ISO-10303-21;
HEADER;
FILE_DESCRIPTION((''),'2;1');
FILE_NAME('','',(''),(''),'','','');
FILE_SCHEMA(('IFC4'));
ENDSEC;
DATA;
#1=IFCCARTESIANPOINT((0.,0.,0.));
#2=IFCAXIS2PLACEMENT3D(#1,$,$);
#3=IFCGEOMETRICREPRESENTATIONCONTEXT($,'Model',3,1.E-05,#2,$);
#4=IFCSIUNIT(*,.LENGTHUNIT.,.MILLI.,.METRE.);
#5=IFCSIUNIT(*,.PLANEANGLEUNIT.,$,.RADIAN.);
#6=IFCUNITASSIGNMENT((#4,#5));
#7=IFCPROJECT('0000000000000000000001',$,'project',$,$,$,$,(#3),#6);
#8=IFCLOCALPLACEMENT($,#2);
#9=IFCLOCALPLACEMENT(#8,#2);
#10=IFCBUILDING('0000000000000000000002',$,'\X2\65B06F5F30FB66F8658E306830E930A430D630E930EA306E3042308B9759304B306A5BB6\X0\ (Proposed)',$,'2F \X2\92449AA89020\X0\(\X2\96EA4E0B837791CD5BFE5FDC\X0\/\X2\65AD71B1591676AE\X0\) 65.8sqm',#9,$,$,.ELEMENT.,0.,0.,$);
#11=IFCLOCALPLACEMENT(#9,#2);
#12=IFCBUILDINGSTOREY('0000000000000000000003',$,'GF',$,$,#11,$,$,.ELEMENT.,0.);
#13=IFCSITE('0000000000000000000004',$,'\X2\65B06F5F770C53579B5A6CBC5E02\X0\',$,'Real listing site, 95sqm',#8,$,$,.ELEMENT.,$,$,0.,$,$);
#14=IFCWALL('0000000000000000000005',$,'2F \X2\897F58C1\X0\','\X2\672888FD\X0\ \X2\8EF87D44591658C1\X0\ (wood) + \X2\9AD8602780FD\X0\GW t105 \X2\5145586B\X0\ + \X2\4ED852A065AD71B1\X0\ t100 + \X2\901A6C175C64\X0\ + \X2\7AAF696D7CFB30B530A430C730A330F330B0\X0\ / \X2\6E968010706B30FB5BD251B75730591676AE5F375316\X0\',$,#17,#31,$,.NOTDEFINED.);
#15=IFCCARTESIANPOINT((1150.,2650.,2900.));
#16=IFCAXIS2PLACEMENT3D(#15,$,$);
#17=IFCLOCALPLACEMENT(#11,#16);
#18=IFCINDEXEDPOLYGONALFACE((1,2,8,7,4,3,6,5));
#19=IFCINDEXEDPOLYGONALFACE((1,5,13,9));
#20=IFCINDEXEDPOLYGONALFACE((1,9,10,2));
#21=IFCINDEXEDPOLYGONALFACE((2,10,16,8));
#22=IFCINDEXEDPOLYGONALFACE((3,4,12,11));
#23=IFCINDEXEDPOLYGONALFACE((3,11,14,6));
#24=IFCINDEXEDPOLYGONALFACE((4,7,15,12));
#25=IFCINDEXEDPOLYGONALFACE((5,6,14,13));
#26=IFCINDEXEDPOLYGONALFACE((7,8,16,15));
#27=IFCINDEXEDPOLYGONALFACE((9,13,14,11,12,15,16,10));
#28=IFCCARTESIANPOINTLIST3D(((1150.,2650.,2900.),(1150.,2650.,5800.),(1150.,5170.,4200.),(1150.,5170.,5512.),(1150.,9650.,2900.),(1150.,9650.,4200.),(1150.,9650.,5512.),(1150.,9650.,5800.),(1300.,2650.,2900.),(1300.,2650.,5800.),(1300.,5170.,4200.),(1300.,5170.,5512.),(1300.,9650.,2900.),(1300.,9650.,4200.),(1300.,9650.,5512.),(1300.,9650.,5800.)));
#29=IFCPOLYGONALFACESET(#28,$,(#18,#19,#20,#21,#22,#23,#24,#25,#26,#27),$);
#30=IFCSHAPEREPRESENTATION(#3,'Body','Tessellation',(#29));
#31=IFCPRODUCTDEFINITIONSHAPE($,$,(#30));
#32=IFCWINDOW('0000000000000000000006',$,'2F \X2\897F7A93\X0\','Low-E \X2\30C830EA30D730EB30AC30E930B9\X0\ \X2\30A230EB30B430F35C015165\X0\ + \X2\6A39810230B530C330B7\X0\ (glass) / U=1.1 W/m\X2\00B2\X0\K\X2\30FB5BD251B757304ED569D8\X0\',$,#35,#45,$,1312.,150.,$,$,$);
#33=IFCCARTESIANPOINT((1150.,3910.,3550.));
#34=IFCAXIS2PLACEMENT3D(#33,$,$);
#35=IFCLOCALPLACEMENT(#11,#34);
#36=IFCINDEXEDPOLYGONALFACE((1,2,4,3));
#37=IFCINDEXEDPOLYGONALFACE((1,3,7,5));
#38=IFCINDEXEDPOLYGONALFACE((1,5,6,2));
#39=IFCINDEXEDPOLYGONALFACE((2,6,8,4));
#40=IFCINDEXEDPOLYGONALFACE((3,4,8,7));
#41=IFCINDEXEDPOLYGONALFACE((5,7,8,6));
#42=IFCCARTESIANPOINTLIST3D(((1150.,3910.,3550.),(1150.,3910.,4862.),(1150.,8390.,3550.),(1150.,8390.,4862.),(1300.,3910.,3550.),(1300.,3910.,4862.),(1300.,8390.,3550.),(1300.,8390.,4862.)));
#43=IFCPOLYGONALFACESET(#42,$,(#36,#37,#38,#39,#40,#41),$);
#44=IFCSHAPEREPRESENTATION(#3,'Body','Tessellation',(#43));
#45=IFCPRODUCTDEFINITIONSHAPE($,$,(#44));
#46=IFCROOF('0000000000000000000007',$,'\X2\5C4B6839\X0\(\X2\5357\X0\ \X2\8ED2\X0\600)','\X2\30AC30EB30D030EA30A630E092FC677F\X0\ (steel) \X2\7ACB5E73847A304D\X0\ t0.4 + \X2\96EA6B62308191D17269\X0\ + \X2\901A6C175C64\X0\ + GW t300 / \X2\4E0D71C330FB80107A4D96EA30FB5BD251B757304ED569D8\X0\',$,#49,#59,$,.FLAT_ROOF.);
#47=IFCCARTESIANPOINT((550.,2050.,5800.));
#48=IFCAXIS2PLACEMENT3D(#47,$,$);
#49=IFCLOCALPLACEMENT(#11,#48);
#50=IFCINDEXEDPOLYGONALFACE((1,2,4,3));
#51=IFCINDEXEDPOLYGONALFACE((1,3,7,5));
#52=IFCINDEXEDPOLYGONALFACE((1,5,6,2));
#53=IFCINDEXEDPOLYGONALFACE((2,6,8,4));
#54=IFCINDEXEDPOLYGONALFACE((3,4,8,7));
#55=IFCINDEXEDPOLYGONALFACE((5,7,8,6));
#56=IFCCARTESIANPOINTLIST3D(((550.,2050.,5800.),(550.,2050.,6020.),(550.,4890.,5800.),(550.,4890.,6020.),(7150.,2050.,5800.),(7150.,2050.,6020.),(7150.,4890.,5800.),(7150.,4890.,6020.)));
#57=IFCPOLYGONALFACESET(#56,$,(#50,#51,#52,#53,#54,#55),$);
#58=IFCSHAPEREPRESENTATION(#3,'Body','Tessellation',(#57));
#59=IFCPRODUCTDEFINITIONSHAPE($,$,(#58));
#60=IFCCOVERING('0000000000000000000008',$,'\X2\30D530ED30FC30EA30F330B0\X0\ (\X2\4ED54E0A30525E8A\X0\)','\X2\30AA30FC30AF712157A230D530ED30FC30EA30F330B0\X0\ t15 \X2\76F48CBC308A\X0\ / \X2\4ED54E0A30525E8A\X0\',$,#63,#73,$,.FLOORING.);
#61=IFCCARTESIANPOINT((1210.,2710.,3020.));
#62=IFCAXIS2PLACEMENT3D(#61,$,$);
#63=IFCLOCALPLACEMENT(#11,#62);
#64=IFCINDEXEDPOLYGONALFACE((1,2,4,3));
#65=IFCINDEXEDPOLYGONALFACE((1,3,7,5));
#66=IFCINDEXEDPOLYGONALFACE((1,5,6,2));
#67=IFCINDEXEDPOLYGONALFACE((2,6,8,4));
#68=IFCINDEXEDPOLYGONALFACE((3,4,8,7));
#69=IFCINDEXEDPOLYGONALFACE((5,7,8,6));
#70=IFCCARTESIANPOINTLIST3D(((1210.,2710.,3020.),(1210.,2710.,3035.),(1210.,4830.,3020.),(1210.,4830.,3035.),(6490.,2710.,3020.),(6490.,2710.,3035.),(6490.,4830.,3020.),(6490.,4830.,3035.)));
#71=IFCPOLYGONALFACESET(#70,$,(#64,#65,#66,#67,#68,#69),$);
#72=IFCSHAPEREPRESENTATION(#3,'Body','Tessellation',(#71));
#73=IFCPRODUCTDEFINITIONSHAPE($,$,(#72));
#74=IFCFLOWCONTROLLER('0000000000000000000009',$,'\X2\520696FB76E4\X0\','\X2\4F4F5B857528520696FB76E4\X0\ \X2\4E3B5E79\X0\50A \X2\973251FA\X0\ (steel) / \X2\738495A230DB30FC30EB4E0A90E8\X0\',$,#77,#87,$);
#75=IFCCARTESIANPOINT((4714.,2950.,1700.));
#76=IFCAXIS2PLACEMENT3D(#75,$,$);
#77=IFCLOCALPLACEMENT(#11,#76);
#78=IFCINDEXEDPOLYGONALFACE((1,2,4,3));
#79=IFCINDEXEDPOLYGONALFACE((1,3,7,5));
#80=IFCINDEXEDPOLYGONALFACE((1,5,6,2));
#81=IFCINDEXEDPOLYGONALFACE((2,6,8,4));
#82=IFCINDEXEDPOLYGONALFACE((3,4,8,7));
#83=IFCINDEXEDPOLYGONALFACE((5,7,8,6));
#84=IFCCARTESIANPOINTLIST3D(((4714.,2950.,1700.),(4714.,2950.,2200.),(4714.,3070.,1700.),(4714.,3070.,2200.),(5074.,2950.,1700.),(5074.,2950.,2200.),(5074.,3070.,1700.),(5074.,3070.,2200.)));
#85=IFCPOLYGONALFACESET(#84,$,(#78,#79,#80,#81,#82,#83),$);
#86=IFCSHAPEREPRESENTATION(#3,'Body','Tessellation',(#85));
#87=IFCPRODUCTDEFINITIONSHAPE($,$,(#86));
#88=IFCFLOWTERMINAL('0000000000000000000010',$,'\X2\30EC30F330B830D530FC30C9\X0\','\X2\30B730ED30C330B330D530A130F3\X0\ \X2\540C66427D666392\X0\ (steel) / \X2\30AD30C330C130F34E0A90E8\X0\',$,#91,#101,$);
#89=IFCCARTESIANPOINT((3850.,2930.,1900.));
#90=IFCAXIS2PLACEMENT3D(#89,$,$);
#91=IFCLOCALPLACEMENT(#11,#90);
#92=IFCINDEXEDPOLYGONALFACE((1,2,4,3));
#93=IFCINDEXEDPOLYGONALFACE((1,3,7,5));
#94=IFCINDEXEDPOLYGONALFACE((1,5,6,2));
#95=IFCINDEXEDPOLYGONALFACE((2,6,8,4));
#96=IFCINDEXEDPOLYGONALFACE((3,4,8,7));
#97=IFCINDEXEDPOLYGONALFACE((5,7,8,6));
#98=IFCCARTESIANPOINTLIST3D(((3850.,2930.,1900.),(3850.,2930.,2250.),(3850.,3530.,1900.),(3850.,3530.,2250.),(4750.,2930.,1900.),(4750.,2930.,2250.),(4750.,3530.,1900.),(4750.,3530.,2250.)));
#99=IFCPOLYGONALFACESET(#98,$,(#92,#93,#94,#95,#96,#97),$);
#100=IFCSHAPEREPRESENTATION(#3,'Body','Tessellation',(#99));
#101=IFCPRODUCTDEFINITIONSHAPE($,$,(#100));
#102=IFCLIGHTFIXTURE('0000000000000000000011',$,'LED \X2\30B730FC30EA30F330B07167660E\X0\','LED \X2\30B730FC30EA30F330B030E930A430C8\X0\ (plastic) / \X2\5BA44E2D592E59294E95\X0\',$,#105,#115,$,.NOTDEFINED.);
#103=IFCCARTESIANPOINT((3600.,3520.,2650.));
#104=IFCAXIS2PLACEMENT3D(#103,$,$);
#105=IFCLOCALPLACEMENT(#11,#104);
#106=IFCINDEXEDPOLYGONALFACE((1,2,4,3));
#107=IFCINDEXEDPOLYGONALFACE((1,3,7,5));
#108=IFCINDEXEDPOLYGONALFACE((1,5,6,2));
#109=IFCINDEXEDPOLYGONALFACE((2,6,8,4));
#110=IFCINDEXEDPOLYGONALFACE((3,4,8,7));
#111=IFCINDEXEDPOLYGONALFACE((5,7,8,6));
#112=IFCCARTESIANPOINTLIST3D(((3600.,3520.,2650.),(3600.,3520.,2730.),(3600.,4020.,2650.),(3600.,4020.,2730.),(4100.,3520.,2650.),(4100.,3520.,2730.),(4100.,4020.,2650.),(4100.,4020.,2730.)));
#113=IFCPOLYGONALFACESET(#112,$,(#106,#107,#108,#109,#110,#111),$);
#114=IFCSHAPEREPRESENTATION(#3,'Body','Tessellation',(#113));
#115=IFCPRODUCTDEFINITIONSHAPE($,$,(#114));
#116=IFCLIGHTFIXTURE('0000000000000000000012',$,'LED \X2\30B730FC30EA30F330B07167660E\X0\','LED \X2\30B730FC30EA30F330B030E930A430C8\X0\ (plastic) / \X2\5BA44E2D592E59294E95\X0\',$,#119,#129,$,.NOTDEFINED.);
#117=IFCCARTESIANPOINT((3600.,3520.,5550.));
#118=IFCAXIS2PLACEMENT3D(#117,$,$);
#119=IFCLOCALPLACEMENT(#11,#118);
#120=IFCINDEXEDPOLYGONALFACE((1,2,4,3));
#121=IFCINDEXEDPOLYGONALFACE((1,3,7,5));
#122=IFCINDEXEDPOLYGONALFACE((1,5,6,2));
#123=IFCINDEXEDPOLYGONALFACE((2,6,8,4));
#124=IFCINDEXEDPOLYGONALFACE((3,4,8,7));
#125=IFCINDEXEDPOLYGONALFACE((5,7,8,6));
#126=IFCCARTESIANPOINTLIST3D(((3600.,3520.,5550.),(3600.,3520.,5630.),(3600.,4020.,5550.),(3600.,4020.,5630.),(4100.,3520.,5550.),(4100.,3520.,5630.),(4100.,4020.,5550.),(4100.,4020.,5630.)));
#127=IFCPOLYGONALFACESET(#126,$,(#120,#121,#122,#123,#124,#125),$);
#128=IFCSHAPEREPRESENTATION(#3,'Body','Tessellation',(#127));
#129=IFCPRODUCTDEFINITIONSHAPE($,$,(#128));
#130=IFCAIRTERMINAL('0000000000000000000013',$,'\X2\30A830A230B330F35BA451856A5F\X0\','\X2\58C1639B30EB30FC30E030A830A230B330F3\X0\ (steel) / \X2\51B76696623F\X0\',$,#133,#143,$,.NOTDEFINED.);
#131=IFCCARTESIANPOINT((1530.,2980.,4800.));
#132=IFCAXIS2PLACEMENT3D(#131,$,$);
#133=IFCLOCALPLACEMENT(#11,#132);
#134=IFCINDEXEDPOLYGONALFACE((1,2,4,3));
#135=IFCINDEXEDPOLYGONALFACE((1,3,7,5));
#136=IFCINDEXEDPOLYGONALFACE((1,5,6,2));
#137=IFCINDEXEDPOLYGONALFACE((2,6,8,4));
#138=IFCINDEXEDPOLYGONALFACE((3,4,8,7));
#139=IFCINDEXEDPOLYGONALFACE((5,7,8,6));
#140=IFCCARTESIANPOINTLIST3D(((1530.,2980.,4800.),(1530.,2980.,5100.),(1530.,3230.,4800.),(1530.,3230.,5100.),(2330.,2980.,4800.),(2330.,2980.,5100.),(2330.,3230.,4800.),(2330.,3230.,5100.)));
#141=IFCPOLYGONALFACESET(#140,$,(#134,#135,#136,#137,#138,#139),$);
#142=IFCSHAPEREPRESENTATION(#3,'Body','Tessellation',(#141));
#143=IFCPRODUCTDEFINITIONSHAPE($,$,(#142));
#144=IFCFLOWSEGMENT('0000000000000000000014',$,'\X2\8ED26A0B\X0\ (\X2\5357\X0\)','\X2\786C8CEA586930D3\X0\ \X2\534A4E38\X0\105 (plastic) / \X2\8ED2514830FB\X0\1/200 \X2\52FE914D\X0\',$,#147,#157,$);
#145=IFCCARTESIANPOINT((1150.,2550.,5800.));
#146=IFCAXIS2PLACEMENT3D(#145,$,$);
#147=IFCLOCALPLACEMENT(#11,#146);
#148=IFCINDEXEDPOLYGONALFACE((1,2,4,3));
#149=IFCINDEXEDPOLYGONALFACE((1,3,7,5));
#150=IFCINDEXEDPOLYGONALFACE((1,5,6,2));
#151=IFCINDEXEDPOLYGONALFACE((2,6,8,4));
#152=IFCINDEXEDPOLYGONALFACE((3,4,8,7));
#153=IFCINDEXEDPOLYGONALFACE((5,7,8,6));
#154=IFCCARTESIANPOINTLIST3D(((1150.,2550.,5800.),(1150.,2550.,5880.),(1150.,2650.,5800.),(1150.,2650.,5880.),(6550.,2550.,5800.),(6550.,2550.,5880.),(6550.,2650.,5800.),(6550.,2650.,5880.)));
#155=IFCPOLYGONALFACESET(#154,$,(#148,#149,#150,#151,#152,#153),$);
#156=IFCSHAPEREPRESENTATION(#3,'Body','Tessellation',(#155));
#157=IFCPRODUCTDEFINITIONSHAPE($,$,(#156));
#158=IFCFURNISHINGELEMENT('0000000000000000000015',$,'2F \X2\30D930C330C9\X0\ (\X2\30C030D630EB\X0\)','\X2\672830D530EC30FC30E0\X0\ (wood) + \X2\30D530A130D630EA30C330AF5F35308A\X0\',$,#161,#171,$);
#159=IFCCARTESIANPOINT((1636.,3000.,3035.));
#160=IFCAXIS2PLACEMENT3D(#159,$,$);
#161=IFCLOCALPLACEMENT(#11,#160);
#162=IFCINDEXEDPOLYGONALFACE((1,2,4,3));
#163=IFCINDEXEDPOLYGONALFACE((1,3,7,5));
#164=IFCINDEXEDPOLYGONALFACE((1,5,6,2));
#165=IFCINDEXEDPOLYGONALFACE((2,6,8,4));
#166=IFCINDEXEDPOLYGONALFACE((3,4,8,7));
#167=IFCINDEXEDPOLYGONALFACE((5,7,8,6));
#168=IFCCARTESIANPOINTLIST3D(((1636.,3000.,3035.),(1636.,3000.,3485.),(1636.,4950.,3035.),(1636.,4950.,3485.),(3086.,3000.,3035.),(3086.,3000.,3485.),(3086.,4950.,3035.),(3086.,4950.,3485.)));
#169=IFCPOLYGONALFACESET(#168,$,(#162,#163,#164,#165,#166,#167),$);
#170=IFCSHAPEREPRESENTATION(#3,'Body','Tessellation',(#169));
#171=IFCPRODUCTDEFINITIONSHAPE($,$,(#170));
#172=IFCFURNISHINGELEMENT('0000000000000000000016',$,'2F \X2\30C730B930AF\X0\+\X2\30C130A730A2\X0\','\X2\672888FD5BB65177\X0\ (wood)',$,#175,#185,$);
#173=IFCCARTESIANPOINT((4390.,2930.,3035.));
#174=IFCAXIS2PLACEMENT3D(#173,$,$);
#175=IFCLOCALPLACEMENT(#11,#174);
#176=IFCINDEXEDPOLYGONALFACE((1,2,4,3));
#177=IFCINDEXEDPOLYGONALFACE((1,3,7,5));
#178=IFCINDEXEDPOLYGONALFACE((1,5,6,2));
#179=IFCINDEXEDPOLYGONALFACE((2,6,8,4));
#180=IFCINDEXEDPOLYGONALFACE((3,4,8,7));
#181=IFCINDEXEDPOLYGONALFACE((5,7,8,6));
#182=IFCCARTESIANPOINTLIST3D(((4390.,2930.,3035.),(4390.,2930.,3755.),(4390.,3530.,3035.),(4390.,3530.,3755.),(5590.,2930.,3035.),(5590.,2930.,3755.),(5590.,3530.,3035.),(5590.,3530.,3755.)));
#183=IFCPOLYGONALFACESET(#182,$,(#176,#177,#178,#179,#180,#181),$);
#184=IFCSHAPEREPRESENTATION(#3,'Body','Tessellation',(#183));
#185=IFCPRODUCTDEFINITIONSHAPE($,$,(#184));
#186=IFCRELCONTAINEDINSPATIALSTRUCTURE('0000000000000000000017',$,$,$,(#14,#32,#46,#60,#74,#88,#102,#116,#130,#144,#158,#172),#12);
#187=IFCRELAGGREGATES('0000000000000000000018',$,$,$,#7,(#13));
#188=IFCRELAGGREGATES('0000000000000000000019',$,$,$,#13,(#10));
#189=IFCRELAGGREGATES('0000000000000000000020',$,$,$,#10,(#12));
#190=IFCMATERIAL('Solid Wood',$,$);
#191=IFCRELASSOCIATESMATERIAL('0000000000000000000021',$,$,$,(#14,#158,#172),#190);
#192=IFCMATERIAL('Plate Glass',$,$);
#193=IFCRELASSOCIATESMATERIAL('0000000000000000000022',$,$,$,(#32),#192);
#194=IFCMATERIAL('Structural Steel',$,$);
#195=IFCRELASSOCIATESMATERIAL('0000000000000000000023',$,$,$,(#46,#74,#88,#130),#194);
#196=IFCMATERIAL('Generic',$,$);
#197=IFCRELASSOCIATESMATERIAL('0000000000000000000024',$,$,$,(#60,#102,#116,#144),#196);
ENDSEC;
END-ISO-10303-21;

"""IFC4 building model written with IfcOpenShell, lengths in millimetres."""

from ifc_helpers import new_model, si_unit, frame, frame_2d, origin, place, context, project, spatial, rectangle, extrude, material, element, fill, save


model = new_model("IFC4")

# Units and contexts
model_context = context("Model", 3, precision=1e-05, world=origin())
ifc_project = project(units=[si_unit("LENGTHUNIT", "METRE", prefix="MILLI"), si_unit("PLANEANGLEUNIT", "RADIAN")], contexts=[model_context])

# Site, building, storey
site_placement = place(None, origin())
site = spatial("IfcSite", under=ifc_project, at=site_placement, Name="新潟県南魚沼市", ObjectType="Real listing site, 95sqm", CompositionType="ELEMENT", RefElevation=0.0)
building_placement = place(site_placement, origin())
building = spatial("IfcBuilding", under=site, at=building_placement, Name="新潟・書斎とライブラリのある静かな家 (Proposed)", ObjectType="2F 鉄骨造(雪下荷重対応/断熱外皮) 65.8sqm", CompositionType="ELEMENT", ElevationOfRefHeight=0.0, ElevationOfTerrain=0.0)
storey_placement = place(building_placement, origin())
storey = spatial("IfcBuildingStorey", under=building, at=storey_placement, Name="GF", CompositionType="ELEMENT", Elevation=0.0)

# Shared definitions
ifc_material_1 = material(Name="Solid Wood")

# Wall, opening, window
ifc_material_2 = material(Name="Plate Glass")
wall_1_placement = place(storey_placement, frame((1150.0, 2650.0, 2900.0)))
wall_1 = element("IfcWall", 1, at=wall_1_placement, inside=storey, material=ifc_material_1, Name="2F 西壁", Description="木製 軸組外壁 (wood) + 高性能GW t105 充填 + 付加断熱 t100 + 通気層 + 窯業系サイディング / 準耐火・寒冷地外皮強化", PredefinedType="NOTDEFINED", context=model_context, shape_type="SweptSolid", body=[
    extrude(rectangle(XDim=150.0, YDim=7000.0, at=frame_2d((75.0, 3500.0))), frame((1150.0, 2650.0, 2900.0)), (0.0, 0.0, 1.0), 2900.0),
])
opening_1_placement = place(storey_placement, frame((1150.0, 3910.0, 3550.0)))
opening_1 = element("IfcOpeningElement", 2, at=opening_1_placement, cuts=wall_1, PredefinedType="NOTDEFINED", context=model_context, shape_type="SweptSolid", body=[
    extrude(rectangle(XDim=150.0, YDim=4480.0, at=frame_2d((75.0, 2240.0))), frame((1150.0, 3910.0, 3550.0)), (0.0, 0.0, 1.0), 1312.0),
])
window_1_placement = place(storey_placement, frame((1150.0, 3910.0, 3550.0)))
window_1 = element("IfcWindow", 3, at=window_1_placement, inside=storey, material=ifc_material_2, Name="2F 西窓", Description="Low-E トリプルガラス アルゴン封入 + 樹脂サッシ (glass) / U=1.1 W/m²K・寒冷地仕様", OverallHeight=1312.0, OverallWidth=150.0, context=model_context, shape_type="SweptSolid", body=[
    extrude(rectangle(XDim=150.0, YDim=4480.0, at=frame_2d((75.0, 2240.0))), frame((1150.0, 3910.0, 3550.0)), (0.0, 0.0, 1.0), 1312.0),
])
fill(opening_1, window_1)

# Roof
ifc_material_3 = material(Name="Structural Steel")
for number, where, name in (
    (4, (550.0, 2050.0, 5800.0), "屋根(南 軒600)"),
):
    element("IfcRoof", number, at=place(storey_placement, frame(where)), inside=storey, material=ifc_material_3, Name=name, Description="ガルバリウム鋼板 (steel) 立平葺き t0.4 + 雪止め金物 + 通気層 + GW t300 / 不燃・耐積雪・寒冷地仕様", PredefinedType="FLAT_ROOF", context=model_context, shape_type="SweptSolid", body=[
        extrude(rectangle(XDim=6600.0, YDim=2840.0, at=frame_2d((3300.0, 1420.0))), frame((550.0, 2050.0, 5800.0)), (0.0, 0.0, 1.0), 220.0),
    ])

# Covering
ifc_material_4 = material(Name="Generic")
covering_placement = place(storey_placement, frame((1210.0, 2710.0, 3020.0)))
element("IfcCovering", 5, at=covering_placement, inside=storey, material=ifc_material_4, Name="フローリング (仕上げ床)", Description="オーク無垢フローリング t15 直貼り / 仕上げ床", PredefinedType="FLOORING", context=model_context, shape_type="SweptSolid", body=[
    extrude(rectangle(XDim=5280.0, YDim=2120.0, at=frame_2d((2640.0, 1060.0))), frame((1210.0, 2710.0, 3020.0)), (0.0, 0.0, 1.0), 15.0),
])

# Flow controller
flow_controller_placement = place(storey_placement, frame((4714.0, 2950.0, 1700.0)))
element("IfcFlowController", 6, at=flow_controller_placement, inside=storey, material=ifc_material_3, Name="分電盤", Description="住宅用分電盤 主幹50A 露出 (steel) / 玄関ホール上部", context=model_context, shape_type="SweptSolid", body=[
    extrude(rectangle(XDim=360.0, YDim=120.0, at=frame_2d((180.0, 60.0))), frame((4714.0, 2950.0, 1700.0)), (0.0, 0.0, 1.0), 500.0),
])

# Flow terminal
flow_terminal_placement = place(storey_placement, frame((3850.0, 2930.0, 1900.0)))
element("IfcFlowTerminal", 7, at=flow_terminal_placement, inside=storey, material=ifc_material_3, Name="レンジフード", Description="シロッコファン 同時給排 (steel) / キッチン上部", context=model_context, shape_type="SweptSolid", body=[
    extrude(rectangle(XDim=900.0, YDim=600.0, at=frame_2d((450.0, 300.0))), frame((3850.0, 2930.0, 1900.0)), (0.0, 0.0, 1.0), 350.0),
])

# Light fixtures
light_fixture_1_placement = place(storey_placement, frame((3600.0, 3520.0, 2650.0)))
element("IfcLightFixture", 8, at=light_fixture_1_placement, inside=storey, material=ifc_material_4, Name="LED シーリング照明", Description="LED シーリングライト (plastic) / 室中央天井", PredefinedType="NOTDEFINED", context=model_context, shape_type="SweptSolid", body=[
    extrude(rectangle(XDim=500.0, YDim=500.0, at=frame_2d((250.0, 250.0))), frame((3600.0, 3520.0, 2650.0)), (0.0, 0.0, 1.0), 80.0),
])
light_fixture_2_placement = place(storey_placement, frame((3600.0, 3520.0, 5550.0)))
element("IfcLightFixture", 9, at=light_fixture_2_placement, inside=storey, material=ifc_material_4, Name="LED シーリング照明", Description="LED シーリングライト (plastic) / 室中央天井", PredefinedType="NOTDEFINED", context=model_context, shape_type="SweptSolid", body=[
    extrude(rectangle(XDim=500.0, YDim=500.0, at=frame_2d((250.0, 250.0))), frame((3600.0, 3520.0, 5550.0)), (0.0, 0.0, 1.0), 80.0),
])

# Air terminal
air_terminal_placement = place(storey_placement, frame((1530.0, 2980.0, 4800.0)))
element("IfcAirTerminal", 10, at=air_terminal_placement, inside=storey, material=ifc_material_3, Name="エアコン室内機", Description="壁掛ルームエアコン (steel) / 冷暖房", PredefinedType="NOTDEFINED", context=model_context, shape_type="SweptSolid", body=[
    extrude(rectangle(XDim=800.0, YDim=250.0, at=frame_2d((400.0, 125.0))), frame((1530.0, 2980.0, 4800.0)), (0.0, 0.0, 1.0), 300.0),
])

# Flow segment
flow_segment_placement = place(storey_placement, frame((1150.0, 2550.0, 5800.0)))
element("IfcFlowSegment", 11, at=flow_segment_placement, inside=storey, material=ifc_material_4, Name="軒樋 (南)", Description="硬質塩ビ 半丸105 (plastic) / 軒先・1/200 勾配", context=model_context, shape_type="SweptSolid", body=[
    extrude(rectangle(XDim=5400.0, YDim=100.0, at=frame_2d((2700.0, 50.0))), frame((1150.0, 2550.0, 5800.0)), (0.0, 0.0, 1.0), 80.0),
])

# Furnishing elements
furnishing_1_placement = place(storey_placement, frame((1636.0, 3000.0, 3035.0)))
element("IfcFurnishingElement", 12, at=furnishing_1_placement, inside=storey, material=ifc_material_1, Name="2F ベッド (ダブル)", Description="木フレーム (wood) + ファブリック張り", context=model_context, shape_type="SweptSolid", body=[
    extrude(rectangle(XDim=1450.0, YDim=1950.0, at=frame_2d((725.0, 975.0))), frame((1636.0, 3000.0, 3035.0)), (0.0, 0.0, 1.0), 450.0),
])
furnishing_2_placement = place(storey_placement, frame((4390.0, 2930.0, 3035.0)))
element("IfcFurnishingElement", 13, at=furnishing_2_placement, inside=storey, material=ifc_material_1, Name="2F デスク+チェア", Description="木製家具 (wood)", context=model_context, shape_type="SweptSolid", body=[
    extrude(rectangle(XDim=1200.0, YDim=600.0, at=frame_2d((600.0, 300.0))), frame((4390.0, 2930.0, 3035.0)), (0.0, 0.0, 1.0), 720.0),
])

save(model, "model.ifc")
